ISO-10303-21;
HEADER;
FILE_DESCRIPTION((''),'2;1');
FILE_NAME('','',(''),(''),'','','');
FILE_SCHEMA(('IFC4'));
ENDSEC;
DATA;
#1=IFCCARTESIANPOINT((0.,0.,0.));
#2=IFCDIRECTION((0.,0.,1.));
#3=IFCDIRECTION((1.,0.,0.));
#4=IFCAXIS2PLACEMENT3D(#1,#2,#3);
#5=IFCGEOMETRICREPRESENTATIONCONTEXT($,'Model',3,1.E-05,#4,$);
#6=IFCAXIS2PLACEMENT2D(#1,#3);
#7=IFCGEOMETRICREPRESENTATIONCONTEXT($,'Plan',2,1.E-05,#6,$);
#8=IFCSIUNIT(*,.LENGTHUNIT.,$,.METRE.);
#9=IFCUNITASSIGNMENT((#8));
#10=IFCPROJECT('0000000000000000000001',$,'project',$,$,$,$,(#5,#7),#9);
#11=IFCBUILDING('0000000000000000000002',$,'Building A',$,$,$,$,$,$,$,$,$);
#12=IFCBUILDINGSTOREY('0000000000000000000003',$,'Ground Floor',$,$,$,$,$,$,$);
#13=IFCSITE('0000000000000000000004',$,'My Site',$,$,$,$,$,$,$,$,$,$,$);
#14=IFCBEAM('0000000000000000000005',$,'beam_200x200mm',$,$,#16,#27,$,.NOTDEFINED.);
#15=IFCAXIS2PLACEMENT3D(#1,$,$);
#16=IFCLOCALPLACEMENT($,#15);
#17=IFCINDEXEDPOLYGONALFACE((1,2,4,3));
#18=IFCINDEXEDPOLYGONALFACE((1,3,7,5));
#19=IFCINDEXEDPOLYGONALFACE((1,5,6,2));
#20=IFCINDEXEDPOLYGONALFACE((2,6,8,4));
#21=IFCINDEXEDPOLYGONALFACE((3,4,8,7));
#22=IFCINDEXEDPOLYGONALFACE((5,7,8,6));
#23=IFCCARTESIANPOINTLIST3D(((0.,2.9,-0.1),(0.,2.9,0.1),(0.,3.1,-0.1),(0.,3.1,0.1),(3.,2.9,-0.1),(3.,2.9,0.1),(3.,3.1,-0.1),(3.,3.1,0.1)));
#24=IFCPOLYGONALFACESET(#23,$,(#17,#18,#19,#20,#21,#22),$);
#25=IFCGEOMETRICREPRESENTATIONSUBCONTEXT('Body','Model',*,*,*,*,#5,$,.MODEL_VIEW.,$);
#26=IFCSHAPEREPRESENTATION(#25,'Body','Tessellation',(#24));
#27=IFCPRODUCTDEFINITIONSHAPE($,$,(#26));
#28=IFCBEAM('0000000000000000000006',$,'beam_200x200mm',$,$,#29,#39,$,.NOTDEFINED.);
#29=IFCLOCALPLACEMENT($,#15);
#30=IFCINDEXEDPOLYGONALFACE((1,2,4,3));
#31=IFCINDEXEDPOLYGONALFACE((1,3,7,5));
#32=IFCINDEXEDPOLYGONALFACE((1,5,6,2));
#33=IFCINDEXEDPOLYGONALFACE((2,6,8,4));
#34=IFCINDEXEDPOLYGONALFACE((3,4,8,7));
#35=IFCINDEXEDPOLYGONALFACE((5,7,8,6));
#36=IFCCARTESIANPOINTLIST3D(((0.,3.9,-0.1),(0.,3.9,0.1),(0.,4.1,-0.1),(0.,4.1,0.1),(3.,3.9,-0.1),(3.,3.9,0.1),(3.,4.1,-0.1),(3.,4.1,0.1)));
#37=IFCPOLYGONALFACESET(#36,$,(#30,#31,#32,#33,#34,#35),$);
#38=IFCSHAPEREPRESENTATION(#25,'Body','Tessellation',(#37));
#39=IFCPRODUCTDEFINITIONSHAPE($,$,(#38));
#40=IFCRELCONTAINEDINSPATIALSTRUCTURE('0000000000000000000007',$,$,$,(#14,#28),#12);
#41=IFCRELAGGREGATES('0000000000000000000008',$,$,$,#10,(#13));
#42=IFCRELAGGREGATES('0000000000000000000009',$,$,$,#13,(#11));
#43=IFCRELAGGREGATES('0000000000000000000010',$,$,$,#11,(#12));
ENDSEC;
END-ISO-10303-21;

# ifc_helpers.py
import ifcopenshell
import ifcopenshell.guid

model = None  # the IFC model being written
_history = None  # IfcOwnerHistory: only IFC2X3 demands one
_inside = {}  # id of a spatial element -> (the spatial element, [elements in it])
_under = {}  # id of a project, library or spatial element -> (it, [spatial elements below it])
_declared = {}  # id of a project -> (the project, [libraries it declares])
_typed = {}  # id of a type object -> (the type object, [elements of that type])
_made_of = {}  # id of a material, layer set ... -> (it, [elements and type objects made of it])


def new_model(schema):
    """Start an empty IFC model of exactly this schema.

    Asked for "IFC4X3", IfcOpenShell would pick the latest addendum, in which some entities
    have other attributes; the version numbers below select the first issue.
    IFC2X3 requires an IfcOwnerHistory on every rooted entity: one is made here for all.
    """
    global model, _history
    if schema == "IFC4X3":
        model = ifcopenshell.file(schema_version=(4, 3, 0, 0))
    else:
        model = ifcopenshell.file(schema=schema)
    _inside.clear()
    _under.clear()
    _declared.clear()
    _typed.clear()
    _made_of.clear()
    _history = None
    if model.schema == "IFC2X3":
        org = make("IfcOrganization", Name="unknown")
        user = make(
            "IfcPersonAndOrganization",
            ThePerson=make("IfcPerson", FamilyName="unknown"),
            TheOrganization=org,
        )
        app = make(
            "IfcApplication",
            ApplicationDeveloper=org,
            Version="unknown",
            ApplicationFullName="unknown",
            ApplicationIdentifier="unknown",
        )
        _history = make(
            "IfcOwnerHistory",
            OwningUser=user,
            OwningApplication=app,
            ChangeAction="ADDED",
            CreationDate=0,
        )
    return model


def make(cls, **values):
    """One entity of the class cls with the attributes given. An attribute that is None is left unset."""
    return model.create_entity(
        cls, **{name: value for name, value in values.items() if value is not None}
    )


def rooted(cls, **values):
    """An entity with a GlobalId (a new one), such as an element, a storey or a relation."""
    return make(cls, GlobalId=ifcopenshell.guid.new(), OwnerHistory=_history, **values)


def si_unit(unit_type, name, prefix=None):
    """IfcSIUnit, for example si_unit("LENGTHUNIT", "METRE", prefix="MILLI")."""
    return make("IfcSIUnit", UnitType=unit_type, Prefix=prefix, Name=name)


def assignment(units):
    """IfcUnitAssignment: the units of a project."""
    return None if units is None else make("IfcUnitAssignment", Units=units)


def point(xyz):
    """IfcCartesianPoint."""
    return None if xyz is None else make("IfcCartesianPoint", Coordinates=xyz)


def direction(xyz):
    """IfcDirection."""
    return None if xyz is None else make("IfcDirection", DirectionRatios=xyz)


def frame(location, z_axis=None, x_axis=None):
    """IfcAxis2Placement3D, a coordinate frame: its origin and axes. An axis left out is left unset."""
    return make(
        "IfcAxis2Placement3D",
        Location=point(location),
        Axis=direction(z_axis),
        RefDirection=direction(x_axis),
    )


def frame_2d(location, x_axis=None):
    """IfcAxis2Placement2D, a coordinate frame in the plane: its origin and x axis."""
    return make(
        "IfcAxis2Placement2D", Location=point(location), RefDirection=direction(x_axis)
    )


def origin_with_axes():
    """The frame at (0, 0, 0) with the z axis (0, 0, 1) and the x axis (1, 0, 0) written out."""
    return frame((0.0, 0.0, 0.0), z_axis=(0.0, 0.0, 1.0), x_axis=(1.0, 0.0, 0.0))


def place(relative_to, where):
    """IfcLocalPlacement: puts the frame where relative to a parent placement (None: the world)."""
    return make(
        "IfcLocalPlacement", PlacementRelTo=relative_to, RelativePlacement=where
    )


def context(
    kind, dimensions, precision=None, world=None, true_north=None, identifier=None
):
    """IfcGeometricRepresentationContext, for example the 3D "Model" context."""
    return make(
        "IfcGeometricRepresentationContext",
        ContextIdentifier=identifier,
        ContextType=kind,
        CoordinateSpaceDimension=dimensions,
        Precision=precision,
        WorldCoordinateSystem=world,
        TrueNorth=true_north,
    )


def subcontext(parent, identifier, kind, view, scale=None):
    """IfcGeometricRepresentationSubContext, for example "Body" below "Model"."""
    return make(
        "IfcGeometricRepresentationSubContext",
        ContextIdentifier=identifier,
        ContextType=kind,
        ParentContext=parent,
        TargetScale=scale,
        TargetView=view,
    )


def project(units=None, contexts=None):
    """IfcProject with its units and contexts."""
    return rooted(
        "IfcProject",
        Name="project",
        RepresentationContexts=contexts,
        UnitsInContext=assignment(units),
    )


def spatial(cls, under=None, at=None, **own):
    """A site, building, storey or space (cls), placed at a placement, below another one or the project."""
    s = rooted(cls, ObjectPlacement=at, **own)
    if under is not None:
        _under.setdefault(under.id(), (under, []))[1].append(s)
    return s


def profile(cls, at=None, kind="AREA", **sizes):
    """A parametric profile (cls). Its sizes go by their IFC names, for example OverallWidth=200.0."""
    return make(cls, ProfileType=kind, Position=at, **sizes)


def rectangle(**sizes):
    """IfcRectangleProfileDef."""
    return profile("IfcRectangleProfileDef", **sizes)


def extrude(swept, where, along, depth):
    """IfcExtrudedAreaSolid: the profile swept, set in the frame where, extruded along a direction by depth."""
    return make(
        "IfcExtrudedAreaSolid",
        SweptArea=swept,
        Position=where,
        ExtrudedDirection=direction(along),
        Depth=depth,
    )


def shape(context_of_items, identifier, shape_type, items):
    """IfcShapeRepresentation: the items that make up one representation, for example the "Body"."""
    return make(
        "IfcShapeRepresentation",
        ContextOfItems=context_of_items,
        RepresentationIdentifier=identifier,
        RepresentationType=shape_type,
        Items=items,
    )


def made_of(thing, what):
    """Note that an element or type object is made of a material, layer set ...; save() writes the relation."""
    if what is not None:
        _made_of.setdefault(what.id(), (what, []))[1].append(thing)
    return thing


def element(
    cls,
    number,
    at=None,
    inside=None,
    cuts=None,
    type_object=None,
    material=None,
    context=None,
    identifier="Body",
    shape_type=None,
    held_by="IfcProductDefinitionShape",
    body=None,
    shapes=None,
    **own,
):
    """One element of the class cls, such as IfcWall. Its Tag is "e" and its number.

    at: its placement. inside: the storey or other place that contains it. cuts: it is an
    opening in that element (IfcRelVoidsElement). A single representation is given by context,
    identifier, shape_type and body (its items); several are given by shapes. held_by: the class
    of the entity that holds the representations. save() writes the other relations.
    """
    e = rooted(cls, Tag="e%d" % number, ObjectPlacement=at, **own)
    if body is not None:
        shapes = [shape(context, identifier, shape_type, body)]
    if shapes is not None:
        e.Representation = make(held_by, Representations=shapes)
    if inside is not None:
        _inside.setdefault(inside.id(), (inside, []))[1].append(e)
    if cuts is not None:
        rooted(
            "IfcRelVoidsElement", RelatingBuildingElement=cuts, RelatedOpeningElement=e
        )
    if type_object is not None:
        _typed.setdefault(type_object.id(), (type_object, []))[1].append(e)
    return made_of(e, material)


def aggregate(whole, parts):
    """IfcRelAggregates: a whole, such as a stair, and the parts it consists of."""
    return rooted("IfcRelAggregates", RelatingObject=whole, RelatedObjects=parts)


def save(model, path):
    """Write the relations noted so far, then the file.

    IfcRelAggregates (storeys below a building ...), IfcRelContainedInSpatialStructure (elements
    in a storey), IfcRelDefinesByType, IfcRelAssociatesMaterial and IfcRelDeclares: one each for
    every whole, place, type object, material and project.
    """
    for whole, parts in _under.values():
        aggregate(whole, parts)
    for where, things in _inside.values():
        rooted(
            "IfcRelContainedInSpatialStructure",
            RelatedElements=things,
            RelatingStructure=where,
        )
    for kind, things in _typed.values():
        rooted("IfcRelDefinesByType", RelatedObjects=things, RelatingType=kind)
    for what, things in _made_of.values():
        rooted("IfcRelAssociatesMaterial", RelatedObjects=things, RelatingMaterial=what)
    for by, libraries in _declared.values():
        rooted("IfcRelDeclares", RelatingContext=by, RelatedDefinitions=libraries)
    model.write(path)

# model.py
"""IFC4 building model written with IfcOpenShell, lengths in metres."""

from ifc_helpers import new_model, si_unit, frame, frame_2d, origin_with_axes, place, context, subcontext, project, spatial, rectangle, extrude, element, save


model = new_model("IFC4")

# Units and contexts
model_context = context("Model", 3, precision=1e-05, world=origin_with_axes())
plan_context = context("Plan", 2, precision=1e-05, world=frame_2d((0.0, 0.0, 0.0), x_axis=(1.0, 0.0, 0.0)))
body_context = subcontext(model_context, "Body", "Model", "MODEL_VIEW")
ifc_project = project(units=[si_unit("LENGTHUNIT", "METRE")], contexts=[model_context, plan_context])

# Site, building, storey
site = spatial("IfcSite", under=ifc_project, Name="My Site")
building = spatial("IfcBuilding", under=site, Name="Building A")
storey = spatial("IfcBuildingStorey", under=building, Name="Ground Floor")

# Beams
for number, where, z_axis, x_axis, name in (
    (1, (0.0, 3.0, 0.0), (1.0, 0.0, 0.0), (0.0, 0.0, 1.0), "beam_200x200mm"),
    (2, (0.0, 4.0, 0.0), (1.0, 0.0, 0.0), (0.0, 0.0, 1.0), "beam_200x200mm"),
):
    element("IfcBeam", number, at=place(None, frame(where, z_axis=z_axis, x_axis=x_axis)), inside=storey, Name=name, PredefinedType="NOTDEFINED", context=body_context, shape_type="SweptSolid", body=[
        extrude(rectangle(XDim=0.2, YDim=0.2), origin_with_axes(), (0.0, 0.0, 1.0), 3.0),
    ])

save(model, "model.ifc")
